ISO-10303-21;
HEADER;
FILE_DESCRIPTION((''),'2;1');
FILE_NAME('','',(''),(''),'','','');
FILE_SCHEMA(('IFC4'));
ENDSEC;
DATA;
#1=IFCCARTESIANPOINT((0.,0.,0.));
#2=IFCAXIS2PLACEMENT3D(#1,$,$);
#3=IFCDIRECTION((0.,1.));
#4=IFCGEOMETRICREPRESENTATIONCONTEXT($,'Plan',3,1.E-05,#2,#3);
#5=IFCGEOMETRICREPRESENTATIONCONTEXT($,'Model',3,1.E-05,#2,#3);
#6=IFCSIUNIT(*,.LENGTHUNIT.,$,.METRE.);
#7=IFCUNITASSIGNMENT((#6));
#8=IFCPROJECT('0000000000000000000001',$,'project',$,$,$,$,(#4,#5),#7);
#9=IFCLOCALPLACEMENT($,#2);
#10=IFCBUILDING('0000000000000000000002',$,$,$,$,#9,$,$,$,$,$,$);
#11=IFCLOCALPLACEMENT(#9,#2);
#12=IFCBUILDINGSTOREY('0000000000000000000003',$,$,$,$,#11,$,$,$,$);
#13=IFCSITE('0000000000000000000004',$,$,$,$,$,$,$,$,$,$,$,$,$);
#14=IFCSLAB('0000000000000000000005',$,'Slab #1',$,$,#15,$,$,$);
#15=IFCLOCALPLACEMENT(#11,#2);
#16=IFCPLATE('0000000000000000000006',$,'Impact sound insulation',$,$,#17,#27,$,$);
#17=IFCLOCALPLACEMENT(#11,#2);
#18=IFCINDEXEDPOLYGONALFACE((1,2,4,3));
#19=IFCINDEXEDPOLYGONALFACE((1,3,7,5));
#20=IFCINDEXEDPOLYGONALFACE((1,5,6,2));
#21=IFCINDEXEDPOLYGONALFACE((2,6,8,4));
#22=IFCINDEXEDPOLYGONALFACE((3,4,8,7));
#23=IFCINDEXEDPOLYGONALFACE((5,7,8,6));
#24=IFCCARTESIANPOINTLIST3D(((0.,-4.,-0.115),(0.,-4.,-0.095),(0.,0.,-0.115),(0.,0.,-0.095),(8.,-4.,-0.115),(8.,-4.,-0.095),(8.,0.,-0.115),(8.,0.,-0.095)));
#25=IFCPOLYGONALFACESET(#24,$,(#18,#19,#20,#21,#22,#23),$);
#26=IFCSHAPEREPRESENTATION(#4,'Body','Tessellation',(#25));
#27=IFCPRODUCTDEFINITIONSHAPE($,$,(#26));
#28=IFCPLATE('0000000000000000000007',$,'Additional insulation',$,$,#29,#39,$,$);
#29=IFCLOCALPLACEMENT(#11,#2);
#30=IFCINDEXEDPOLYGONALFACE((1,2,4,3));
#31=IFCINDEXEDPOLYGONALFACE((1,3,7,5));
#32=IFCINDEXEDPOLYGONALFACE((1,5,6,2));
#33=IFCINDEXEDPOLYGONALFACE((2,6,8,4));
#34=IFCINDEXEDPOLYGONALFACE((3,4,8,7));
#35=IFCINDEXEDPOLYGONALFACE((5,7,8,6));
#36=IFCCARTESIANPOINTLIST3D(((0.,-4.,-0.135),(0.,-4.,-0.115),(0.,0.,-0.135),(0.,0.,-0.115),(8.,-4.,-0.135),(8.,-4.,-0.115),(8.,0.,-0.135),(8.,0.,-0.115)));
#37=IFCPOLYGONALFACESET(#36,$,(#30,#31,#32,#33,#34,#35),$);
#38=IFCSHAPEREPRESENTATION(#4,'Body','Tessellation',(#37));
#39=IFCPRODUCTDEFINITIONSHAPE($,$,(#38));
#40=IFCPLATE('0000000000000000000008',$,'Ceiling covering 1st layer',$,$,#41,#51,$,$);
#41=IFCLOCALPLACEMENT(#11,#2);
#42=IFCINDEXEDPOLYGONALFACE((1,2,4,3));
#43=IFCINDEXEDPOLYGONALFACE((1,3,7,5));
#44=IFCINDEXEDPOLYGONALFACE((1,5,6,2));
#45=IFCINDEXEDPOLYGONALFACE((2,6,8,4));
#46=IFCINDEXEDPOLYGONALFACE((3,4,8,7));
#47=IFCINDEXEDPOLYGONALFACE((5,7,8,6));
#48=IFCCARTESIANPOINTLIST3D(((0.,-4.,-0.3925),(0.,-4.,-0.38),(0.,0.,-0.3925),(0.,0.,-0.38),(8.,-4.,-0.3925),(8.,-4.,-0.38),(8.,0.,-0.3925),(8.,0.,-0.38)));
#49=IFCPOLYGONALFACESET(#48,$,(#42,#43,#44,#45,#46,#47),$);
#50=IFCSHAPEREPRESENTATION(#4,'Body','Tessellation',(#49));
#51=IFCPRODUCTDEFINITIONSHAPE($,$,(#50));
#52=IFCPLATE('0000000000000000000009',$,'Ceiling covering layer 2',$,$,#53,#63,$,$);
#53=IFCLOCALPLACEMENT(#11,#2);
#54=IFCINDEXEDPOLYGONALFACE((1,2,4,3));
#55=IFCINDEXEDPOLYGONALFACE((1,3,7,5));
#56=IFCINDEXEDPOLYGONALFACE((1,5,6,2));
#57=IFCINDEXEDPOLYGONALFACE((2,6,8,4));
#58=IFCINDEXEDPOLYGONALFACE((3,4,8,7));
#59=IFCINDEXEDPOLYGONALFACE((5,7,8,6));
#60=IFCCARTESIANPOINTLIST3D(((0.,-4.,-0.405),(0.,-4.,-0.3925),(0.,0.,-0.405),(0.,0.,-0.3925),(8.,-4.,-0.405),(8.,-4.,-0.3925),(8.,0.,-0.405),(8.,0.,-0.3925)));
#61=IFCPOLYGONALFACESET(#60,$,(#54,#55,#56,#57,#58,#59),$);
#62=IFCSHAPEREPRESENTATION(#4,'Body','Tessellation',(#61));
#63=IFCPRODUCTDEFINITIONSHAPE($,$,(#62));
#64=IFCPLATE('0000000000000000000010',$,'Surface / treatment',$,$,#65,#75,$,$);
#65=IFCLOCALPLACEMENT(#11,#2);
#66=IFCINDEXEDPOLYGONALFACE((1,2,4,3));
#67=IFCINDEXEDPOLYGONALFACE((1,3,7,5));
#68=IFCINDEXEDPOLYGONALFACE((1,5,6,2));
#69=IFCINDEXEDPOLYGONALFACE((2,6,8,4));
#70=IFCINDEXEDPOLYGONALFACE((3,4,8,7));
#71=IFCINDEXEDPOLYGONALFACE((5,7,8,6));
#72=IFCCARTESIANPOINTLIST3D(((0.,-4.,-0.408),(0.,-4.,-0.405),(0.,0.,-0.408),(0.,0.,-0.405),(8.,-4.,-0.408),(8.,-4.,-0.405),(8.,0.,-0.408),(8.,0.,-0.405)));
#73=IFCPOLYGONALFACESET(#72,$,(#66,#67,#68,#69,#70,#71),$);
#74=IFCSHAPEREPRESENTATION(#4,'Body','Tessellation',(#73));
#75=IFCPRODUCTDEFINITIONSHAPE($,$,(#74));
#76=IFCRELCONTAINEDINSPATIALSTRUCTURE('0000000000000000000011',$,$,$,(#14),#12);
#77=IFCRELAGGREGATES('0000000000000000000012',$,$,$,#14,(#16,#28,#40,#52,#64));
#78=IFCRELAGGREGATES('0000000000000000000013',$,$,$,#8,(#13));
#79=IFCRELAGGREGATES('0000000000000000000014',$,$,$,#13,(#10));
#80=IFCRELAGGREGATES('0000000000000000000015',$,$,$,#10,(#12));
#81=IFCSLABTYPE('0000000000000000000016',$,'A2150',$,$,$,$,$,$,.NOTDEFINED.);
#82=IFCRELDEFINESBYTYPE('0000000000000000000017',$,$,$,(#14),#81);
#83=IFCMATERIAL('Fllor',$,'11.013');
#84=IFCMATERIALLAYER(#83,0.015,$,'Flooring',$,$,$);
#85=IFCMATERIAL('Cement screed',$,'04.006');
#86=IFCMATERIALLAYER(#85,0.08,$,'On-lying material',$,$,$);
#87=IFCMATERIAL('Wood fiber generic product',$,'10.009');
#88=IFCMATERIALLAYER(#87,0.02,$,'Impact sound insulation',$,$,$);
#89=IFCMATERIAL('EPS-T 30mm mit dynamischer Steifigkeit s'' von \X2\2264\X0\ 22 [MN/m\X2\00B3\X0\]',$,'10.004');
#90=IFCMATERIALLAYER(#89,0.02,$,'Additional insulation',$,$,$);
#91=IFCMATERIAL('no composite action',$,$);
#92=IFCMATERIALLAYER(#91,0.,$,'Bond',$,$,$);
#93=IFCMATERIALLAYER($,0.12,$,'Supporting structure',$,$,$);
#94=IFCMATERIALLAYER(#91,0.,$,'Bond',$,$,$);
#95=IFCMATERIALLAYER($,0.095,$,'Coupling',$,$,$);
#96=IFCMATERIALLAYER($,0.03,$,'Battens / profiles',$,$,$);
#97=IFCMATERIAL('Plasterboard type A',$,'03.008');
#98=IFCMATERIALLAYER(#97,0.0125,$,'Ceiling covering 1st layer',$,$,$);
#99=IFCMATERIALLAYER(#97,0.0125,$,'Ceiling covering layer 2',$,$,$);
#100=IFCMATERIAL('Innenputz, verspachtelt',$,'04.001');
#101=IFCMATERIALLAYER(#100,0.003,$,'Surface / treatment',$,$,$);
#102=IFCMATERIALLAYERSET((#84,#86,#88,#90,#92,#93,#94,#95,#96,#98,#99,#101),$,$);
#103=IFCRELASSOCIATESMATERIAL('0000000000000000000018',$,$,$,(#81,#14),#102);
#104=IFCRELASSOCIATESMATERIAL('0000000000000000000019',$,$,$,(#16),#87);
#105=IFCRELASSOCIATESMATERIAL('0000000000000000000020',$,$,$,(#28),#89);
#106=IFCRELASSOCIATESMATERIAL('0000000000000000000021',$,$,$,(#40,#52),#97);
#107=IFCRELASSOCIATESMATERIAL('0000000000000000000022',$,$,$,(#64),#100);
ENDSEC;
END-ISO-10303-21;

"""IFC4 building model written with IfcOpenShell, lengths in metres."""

from ifc_helpers import new_model, si_unit, direction, frame, frame_2d, origin, place, context, project, spatial, rectangle, extrude, material, layer, layer_set, type_object, element, aggregate, save


model = new_model("IFC4")

# Units and contexts
plan_context = context("Plan", 3, precision=1e-05, world=origin(), true_north=direction((0.0, 1.0)))
model_context = context("Model", 3, precision=1e-05, world=origin(), true_north=direction((0.0, 1.0)))
ifc_project = project(units=[si_unit("LENGTHUNIT", "METRE")], contexts=[plan_context, model_context])

# Site, building, storey
site = spatial("IfcSite", under=ifc_project)
building_placement = place(None, origin())
building = spatial("IfcBuilding", under=site, at=building_placement)
storey_placement = place(building_placement, origin())
storey = spatial("IfcBuildingStorey", under=building, at=storey_placement)

# Slab, plates
ifc_material_1 = material(Name="Fllor", Category="11.013")
ifc_layer_1 = layer(ifc_material_1, 0.015, Name="Flooring")
ifc_material_2 = material(Name="Cement screed", Category="04.006")
ifc_layer_2 = layer(ifc_material_2, 0.08, Name="On-lying material")
ifc_material_3 = material(Name="Wood fiber generic product", Category="10.009")
ifc_layer_3 = layer(ifc_material_3, 0.02, Name="Impact sound insulation")
ifc_material_4 = material(Name="EPS-T 30mm mit dynamischer Steifigkeit s' von ≤ 22 [MN/m³]", Category="10.004")
ifc_layer_4 = layer(ifc_material_4, 0.02, Name="Additional insulation")
ifc_material_5 = material(Name="no composite action")
ifc_layer_5 = layer(ifc_material_5, 0.0, Name="Bond")
ifc_layer_6 = layer(None, 0.12, Name="Supporting structure")
ifc_layer_7 = layer(ifc_material_5, 0.0, Name="Bond")
ifc_layer_8 = layer(None, 0.095, Name="Coupling")
ifc_layer_9 = layer(None, 0.03, Name="Battens / profiles")
ifc_material_6 = material(Name="Plasterboard type A", Category="03.008")
ifc_layer_10 = layer(ifc_material_6, 0.0125, Name="Ceiling covering 1st layer")
ifc_layer_11 = layer(ifc_material_6, 0.0125, Name="Ceiling covering layer 2")
ifc_material_7 = material(Name="Innenputz, verspachtelt", Category="04.001")
ifc_layer_12 = layer(ifc_material_7, 0.003, Name="Surface / treatment")
ifc_layer_set = layer_set([ifc_layer_1, ifc_layer_2, ifc_layer_3, ifc_layer_4, ifc_layer_5, ifc_layer_6, ifc_layer_7, ifc_layer_8, ifc_layer_9, ifc_layer_10, ifc_layer_11, ifc_layer_12])
slab_type = type_object("IfcSlabType", Name="A2150", PredefinedType="NOTDEFINED", material=ifc_layer_set)
slab_placement = place(None, frame((0.0, 0.0, 0.0), z_axis=(0.0, 0.0, -1.0), x_axis=(1.0, 0.0, 0.0)))
slab = element("IfcSlab", 1, at=slab_placement, inside=storey, type_object=slab_type, material=ifc_layer_set, Name="Slab #1")
plate_1_placement = place(slab_placement, origin())
plate_1 = element("IfcPlate", 2, at=plate_1_placement, material=ifc_material_3, Name="Impact sound insulation", context=plan_context, shape_type="SweptSolid", body=[
    extrude(rectangle(XDim=8.0, YDim=4.0, at=frame_2d((4.0, 2.0), x_axis=(1.0, 0.0))), frame((0.0, 0.0, 0.095), z_axis=(0.0, 0.0, 1.0), x_axis=(1.0, 0.0, 0.0)), (0.0, 0.0, 1.0), 0.02),
])
plate_2_placement = place(slab_placement, origin())
plate_2 = element("IfcPlate", 3, at=plate_2_placement, material=ifc_material_4, Name="Additional insulation", context=plan_context, shape_type="SweptSolid", body=[
    extrude(rectangle(XDim=8.0, YDim=4.0, at=frame_2d((4.0, 2.0), x_axis=(1.0, 0.0))), frame((0.0, 0.0, 0.115), z_axis=(0.0, 0.0, 1.0), x_axis=(1.0, 0.0, 0.0)), (0.0, 0.0, 1.0), 0.02),
])
plate_3_placement = place(slab_placement, origin())
plate_3 = element("IfcPlate", 4, at=plate_3_placement, material=ifc_material_6, Name="Ceiling covering 1st layer", context=plan_context, shape_type="SweptSolid", body=[
    extrude(rectangle(XDim=8.0, YDim=4.0, at=frame_2d((4.0, 2.0), x_axis=(1.0, 0.0))), frame((0.0, 0.0, 0.38), z_axis=(0.0, 0.0, 1.0), x_axis=(1.0, 0.0, 0.0)), (0.0, 0.0, 1.0), 0.0125),
])
plate_4_placement = place(slab_placement, origin())
plate_4 = element("IfcPlate", 5, at=plate_4_placement, material=ifc_material_6, Name="Ceiling covering layer 2", context=plan_context, shape_type="SweptSolid", body=[
    extrude(rectangle(XDim=8.0, YDim=4.0, at=frame_2d((4.0, 2.0), x_axis=(1.0, 0.0))), frame((0.0, 0.0, 0.3925), z_axis=(0.0, 0.0, 1.0), x_axis=(1.0, 0.0, 0.0)), (0.0, 0.0, 1.0), 0.0125),
])
plate_5_placement = place(slab_placement, origin())
plate_5 = element("IfcPlate", 6, at=plate_5_placement, material=ifc_material_7, Name="Surface / treatment", context=plan_context, shape_type="SweptSolid", body=[
    extrude(rectangle(XDim=8.0, YDim=4.0, at=frame_2d((4.0, 2.0), x_axis=(1.0, 0.0))), frame((0.0, 0.0, 0.405), z_axis=(0.0, 0.0, 1.0), x_axis=(1.0, 0.0, 0.0)), (0.0, 0.0, 1.0), 0.003),
])
aggregate(slab, [plate_1, plate_2, plate_3, plate_4, plate_5])

save(model, "model.ifc")
